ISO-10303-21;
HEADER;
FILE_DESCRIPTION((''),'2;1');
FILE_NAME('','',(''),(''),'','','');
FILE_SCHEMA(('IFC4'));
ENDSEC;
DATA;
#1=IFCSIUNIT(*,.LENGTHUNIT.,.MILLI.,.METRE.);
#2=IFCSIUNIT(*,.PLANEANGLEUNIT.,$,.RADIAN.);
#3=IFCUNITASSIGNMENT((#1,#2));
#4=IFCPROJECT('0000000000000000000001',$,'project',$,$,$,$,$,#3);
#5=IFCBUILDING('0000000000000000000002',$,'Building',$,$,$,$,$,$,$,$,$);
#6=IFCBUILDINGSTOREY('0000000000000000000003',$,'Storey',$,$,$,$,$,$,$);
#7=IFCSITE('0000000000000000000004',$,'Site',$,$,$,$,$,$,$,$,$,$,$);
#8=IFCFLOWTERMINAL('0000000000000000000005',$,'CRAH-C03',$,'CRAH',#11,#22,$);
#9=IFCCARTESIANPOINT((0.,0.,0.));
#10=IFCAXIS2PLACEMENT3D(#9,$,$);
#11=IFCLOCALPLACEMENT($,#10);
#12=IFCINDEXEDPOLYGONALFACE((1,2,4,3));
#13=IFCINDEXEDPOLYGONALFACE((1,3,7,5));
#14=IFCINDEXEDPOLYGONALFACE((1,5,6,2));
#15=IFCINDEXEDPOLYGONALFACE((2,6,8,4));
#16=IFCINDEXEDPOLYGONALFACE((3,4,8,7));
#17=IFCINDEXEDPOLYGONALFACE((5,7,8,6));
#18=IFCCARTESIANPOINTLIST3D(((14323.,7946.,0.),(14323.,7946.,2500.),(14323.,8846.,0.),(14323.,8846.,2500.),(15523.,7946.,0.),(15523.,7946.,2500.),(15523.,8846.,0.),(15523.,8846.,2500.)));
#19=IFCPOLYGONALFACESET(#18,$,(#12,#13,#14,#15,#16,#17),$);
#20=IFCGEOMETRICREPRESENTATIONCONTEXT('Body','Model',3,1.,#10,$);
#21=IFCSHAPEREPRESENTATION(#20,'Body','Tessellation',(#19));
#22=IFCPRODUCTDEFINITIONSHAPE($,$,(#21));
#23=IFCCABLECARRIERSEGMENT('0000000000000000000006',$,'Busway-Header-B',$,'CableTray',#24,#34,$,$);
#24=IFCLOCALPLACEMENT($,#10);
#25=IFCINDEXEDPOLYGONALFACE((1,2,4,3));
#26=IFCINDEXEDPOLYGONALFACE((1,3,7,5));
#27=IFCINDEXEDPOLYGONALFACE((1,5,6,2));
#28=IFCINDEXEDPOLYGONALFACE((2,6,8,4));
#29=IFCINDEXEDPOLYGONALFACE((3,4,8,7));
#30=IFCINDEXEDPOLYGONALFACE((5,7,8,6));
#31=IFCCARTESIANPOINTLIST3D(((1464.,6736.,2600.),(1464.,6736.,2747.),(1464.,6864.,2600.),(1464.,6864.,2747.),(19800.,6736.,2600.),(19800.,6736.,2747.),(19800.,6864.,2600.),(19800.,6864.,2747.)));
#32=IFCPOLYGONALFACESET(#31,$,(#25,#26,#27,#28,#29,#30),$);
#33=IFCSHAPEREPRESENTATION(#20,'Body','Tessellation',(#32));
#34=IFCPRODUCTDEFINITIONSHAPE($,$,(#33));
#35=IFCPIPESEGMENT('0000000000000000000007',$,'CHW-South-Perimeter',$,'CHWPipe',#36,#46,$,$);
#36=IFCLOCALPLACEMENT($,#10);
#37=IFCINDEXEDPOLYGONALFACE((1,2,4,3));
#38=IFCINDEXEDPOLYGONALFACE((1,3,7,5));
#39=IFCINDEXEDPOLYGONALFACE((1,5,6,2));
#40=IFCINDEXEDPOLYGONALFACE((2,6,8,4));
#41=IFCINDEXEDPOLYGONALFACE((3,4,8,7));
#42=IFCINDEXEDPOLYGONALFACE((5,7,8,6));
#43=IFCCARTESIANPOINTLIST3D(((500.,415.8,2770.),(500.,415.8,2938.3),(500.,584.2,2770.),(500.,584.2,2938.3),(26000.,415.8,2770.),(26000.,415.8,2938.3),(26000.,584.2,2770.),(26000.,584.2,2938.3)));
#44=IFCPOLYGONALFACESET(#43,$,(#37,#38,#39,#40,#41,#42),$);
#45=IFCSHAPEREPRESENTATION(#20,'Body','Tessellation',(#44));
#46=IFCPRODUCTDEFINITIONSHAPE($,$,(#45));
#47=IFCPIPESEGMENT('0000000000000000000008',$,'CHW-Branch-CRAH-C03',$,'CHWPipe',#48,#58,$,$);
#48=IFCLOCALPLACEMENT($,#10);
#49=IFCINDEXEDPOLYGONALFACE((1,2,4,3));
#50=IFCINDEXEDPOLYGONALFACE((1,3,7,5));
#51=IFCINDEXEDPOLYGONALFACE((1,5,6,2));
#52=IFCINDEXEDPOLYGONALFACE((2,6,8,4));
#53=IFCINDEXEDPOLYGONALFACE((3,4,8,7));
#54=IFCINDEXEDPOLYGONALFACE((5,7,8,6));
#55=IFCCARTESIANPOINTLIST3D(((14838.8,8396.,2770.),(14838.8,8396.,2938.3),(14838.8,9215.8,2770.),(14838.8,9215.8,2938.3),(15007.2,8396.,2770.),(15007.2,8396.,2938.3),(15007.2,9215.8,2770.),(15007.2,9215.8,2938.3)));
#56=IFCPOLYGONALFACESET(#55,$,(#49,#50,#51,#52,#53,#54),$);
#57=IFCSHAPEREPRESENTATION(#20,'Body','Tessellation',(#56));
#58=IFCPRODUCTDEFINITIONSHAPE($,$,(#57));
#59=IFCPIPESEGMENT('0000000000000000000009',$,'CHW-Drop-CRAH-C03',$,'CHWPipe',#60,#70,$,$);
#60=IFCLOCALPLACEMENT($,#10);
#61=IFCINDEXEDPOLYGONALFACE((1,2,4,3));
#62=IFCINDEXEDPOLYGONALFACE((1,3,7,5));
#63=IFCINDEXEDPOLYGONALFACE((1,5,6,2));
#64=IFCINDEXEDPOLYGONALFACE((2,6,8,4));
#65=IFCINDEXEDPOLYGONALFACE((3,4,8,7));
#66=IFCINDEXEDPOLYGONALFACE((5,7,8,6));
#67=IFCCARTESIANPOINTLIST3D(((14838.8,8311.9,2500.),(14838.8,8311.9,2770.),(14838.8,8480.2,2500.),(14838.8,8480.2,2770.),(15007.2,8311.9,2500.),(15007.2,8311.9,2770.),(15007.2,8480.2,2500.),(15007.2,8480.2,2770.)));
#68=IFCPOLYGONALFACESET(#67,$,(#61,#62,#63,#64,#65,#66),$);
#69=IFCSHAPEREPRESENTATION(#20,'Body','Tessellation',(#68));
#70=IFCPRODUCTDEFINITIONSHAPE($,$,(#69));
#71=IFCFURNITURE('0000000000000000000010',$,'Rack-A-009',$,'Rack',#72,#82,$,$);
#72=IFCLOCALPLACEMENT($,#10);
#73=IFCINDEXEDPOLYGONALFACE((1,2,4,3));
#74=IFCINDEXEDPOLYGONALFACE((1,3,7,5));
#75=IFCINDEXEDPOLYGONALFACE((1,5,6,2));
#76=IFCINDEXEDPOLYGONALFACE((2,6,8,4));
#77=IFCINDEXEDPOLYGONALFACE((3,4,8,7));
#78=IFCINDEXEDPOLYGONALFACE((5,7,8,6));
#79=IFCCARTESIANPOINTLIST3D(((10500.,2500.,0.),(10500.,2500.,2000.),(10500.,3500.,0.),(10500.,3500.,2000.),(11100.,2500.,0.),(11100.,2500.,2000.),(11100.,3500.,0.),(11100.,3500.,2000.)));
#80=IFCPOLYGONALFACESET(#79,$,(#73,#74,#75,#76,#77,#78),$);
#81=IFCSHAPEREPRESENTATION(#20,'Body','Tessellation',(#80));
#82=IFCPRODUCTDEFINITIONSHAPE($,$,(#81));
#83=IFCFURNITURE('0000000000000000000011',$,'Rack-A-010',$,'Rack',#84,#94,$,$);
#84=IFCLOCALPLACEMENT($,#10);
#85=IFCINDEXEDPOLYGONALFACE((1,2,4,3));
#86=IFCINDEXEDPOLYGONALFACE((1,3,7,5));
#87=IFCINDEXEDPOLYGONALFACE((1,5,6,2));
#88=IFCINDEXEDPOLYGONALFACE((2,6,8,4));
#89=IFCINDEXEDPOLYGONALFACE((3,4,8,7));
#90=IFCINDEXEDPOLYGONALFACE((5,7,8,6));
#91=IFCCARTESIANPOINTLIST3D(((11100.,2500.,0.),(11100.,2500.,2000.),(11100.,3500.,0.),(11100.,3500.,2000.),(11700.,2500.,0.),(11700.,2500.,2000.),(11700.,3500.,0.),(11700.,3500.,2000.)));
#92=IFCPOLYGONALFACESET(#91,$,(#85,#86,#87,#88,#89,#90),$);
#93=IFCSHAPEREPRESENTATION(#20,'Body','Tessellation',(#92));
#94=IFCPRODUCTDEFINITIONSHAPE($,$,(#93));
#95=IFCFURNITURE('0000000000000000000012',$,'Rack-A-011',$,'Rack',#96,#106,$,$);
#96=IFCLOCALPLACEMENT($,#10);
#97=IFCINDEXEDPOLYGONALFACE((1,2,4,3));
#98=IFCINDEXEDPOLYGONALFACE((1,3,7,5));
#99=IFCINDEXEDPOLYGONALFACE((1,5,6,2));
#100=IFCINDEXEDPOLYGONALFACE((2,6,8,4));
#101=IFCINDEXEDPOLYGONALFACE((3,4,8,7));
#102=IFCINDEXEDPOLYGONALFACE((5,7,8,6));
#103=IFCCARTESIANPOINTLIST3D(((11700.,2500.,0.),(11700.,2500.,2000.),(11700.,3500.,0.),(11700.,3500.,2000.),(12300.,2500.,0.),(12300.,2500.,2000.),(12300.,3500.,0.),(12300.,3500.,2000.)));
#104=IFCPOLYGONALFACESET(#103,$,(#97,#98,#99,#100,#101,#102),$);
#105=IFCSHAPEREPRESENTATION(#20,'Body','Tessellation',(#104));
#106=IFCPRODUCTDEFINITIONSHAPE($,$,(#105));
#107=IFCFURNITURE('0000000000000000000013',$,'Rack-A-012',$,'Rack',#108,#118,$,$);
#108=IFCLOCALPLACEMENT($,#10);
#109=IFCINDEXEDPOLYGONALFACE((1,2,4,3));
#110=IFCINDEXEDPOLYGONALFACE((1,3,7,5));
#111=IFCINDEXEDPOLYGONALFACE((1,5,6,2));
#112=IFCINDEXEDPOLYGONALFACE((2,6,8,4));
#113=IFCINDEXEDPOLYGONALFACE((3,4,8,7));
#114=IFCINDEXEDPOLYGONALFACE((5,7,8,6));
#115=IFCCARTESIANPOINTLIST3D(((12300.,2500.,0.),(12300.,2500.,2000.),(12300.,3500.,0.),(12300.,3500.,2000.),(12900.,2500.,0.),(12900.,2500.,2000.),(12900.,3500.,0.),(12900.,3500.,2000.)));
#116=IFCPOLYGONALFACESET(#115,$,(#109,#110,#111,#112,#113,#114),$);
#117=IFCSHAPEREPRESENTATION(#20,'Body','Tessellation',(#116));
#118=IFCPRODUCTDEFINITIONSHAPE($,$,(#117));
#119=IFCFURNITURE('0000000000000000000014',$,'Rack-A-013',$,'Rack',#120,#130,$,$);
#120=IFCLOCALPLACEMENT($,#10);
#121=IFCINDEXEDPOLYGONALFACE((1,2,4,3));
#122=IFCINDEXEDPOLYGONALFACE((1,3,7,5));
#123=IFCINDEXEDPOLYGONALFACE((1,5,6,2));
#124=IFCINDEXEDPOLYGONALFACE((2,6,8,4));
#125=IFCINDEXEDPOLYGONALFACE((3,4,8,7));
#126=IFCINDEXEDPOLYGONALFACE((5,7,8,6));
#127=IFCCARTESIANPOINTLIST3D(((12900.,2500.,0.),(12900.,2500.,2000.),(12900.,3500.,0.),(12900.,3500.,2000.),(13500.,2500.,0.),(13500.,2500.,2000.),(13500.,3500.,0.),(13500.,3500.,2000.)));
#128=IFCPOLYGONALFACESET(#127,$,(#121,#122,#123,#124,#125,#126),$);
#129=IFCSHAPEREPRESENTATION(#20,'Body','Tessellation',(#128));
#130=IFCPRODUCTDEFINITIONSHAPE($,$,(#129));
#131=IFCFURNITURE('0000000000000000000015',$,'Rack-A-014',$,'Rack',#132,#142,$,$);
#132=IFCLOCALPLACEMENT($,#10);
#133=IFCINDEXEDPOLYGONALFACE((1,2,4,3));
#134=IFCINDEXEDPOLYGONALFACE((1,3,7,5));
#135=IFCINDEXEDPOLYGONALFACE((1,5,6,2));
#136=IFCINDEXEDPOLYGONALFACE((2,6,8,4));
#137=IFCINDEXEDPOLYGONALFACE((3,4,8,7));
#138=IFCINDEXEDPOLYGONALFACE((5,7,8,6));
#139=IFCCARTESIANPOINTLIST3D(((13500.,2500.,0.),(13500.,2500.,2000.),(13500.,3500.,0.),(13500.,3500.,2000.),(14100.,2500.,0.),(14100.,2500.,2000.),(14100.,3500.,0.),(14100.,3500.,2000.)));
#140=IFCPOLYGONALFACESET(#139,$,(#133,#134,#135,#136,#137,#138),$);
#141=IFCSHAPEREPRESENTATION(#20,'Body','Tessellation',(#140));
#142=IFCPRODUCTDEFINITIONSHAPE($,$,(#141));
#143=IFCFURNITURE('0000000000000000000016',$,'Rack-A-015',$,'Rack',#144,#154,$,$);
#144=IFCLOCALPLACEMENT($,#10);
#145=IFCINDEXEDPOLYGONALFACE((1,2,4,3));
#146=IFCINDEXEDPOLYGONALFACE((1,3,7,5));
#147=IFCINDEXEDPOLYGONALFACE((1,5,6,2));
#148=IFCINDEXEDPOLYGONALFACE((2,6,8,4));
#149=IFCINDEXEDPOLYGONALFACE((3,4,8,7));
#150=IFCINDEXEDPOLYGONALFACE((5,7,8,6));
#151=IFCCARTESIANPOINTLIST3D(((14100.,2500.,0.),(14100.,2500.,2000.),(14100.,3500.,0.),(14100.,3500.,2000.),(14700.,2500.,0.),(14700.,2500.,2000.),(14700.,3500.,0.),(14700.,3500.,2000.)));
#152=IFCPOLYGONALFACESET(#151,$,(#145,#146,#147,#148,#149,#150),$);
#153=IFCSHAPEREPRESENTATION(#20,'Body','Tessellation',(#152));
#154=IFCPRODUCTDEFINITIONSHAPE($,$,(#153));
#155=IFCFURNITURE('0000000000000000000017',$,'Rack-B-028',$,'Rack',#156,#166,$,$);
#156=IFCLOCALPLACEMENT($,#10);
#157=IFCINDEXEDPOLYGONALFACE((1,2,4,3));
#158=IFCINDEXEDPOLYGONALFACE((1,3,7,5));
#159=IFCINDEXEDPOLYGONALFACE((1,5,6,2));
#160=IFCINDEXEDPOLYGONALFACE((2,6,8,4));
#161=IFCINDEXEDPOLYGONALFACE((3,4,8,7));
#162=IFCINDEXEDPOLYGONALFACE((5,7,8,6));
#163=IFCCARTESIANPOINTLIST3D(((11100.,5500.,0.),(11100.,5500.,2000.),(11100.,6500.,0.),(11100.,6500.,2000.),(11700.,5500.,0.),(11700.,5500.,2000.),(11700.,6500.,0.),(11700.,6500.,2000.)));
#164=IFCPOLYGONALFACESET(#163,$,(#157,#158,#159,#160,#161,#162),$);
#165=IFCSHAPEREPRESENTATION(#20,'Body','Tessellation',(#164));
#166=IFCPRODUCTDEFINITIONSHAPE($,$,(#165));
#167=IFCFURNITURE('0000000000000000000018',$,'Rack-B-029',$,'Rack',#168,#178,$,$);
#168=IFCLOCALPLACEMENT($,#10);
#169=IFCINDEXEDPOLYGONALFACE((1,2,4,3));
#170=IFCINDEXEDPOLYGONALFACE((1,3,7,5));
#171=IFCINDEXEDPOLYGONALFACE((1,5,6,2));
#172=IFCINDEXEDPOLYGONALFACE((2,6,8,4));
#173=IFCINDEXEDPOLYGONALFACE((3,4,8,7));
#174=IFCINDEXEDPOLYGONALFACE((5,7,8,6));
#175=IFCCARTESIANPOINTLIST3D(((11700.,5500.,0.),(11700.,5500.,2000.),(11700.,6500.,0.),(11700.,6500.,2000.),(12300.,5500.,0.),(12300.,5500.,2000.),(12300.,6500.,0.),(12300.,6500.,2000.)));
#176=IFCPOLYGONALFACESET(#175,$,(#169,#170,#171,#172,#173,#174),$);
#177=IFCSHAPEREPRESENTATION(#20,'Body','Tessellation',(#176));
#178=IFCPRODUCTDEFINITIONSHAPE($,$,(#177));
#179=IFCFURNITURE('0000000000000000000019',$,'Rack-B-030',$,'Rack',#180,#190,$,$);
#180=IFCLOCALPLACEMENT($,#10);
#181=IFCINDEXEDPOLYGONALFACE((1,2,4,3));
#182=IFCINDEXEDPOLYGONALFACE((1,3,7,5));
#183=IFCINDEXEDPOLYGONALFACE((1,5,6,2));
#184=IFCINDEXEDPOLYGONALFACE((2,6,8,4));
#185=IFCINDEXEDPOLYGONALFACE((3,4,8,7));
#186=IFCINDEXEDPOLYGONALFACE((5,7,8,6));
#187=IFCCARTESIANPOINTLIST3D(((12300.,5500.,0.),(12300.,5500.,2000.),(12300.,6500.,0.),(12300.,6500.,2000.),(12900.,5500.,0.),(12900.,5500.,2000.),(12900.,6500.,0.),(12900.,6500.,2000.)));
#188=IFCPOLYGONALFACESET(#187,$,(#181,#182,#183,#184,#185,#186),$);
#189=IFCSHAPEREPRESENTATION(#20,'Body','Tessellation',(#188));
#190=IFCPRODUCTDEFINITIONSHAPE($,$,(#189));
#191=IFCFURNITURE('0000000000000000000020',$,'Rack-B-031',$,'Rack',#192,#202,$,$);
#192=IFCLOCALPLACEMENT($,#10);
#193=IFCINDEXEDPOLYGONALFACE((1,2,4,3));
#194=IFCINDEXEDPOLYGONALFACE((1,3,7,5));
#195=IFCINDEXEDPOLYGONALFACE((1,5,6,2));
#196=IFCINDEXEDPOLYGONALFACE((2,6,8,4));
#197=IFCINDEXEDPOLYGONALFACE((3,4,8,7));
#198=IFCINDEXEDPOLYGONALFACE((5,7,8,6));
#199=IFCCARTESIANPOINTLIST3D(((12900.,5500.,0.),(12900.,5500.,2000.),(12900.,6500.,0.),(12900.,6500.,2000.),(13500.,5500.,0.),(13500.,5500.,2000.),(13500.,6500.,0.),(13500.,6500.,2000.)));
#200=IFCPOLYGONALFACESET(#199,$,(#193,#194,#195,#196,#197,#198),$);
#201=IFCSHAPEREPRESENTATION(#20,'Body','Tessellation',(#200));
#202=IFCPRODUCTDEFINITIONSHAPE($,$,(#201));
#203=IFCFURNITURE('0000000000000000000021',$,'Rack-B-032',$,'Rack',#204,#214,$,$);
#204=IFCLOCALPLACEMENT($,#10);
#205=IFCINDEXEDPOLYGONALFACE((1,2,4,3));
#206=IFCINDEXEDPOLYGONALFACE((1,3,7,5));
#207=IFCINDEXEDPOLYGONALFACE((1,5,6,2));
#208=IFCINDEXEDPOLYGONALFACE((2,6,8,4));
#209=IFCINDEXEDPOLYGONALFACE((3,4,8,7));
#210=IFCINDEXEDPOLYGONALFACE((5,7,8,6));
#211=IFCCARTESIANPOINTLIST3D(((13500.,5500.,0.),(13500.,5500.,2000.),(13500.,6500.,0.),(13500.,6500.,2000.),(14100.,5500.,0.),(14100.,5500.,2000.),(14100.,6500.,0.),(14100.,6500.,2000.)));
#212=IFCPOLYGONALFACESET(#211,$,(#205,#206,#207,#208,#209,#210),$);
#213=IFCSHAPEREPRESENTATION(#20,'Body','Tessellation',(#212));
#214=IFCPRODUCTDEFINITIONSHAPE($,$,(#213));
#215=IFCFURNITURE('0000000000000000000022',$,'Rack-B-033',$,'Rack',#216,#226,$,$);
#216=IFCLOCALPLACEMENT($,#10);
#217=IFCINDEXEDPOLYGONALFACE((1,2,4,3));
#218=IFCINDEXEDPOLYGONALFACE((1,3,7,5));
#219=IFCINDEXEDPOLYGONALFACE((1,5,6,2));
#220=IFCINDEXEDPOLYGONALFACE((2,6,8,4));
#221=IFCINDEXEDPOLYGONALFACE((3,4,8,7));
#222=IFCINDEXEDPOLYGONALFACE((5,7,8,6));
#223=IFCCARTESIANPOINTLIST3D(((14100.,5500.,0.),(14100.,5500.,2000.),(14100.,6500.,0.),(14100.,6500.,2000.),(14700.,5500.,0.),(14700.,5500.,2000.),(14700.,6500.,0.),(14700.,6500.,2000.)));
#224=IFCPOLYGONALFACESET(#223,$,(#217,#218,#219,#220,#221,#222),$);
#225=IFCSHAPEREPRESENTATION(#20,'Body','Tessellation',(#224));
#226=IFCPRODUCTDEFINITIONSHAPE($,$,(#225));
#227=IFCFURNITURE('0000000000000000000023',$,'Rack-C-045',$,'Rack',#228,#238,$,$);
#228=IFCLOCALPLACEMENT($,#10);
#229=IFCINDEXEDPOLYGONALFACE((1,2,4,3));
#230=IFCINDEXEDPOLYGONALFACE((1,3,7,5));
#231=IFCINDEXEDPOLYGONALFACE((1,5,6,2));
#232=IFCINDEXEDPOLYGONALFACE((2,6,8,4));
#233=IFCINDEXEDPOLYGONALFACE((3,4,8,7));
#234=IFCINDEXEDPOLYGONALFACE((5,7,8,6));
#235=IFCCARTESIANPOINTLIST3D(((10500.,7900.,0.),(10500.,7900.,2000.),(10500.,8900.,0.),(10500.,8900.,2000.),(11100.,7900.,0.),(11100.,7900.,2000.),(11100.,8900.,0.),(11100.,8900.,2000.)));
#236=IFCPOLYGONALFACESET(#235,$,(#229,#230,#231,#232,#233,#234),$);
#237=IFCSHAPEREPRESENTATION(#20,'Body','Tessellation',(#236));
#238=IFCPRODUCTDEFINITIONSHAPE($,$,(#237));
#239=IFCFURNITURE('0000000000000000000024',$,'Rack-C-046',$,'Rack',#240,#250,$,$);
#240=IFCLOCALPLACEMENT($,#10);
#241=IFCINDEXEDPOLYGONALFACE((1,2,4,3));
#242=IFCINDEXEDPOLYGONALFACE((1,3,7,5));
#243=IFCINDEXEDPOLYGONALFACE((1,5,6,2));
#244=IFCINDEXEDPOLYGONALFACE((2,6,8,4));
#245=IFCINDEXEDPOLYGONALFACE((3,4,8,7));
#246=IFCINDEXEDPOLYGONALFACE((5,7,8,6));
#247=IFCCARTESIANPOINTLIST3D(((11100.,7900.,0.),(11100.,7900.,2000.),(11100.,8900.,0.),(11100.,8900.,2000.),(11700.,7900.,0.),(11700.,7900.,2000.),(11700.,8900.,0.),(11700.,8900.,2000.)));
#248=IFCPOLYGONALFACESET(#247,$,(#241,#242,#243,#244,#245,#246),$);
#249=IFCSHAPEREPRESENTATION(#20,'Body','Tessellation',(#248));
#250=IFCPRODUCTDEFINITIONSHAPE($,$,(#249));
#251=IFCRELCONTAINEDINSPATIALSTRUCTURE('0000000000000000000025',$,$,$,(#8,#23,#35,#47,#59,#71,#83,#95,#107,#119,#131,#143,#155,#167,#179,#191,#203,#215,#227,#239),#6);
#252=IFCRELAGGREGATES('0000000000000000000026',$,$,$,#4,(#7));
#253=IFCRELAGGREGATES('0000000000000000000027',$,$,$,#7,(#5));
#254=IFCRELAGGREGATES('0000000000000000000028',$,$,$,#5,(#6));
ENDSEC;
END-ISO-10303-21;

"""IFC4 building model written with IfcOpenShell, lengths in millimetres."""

from ifc_helpers import new_model, si_unit, frame, origin, place, context, project, spatial, rectangle, extrude, element, save


model = new_model("IFC4")

# Units and contexts
model_context = context("Model", 3, precision=1.0, world=origin(), identifier="Body")
ifc_project = project(units=[si_unit("LENGTHUNIT", "METRE", prefix="MILLI"), si_unit("PLANEANGLEUNIT", "RADIAN")])

# Site, building, storey
site = spatial("IfcSite", under=ifc_project, Name="Site")
building = spatial("IfcBuilding", under=site, Name="Building")
storey = spatial("IfcBuildingStorey", under=building, Name="Storey")

# Flow terminal
flow_terminal_placement = place(None, frame((14923.0, 8396.0, 0.0), z_axis=(0.0, 0.0, 1.0), x_axis=(1.0, 0.0, 0.0)))
element("IfcFlowTerminal", 1, at=flow_terminal_placement, inside=storey, Name="CRAH-C03", ObjectType="CRAH", context=model_context, shape_type="SweptSolid", body=[
    extrude(rectangle(XDim=1200.0, YDim=900.0), origin(), (0.0, 0.0, 1.0), 2500.0),
])

# Cable carrier segment
cable_carrier_segment_placement = place(None, frame((10632.0, 6800.0, 2600.0), z_axis=(0.0, 0.0, 1.0), x_axis=(1.0, 0.0, 0.0)))
element("IfcCableCarrierSegment", 2, at=cable_carrier_segment_placement, inside=storey, Name="Busway-Header-B", ObjectType="CableTray", context=model_context, shape_type="SweptSolid", body=[
    extrude(rectangle(XDim=18336.0, YDim=128.0), origin(), (0.0, 0.0, 1.0), 147.0),
])

# Pipe segments
pipe_segment_1_placement = place(None, frame((13250.0, 500.0, 2770.0), z_axis=(0.0, 0.0, 1.0), x_axis=(1.0, 0.0, 0.0)))
element("IfcPipeSegment", 3, at=pipe_segment_1_placement, inside=storey, Name="CHW-South-Perimeter", ObjectType="CHWPipe", context=model_context, shape_type="SweptSolid", body=[
    extrude(rectangle(XDim=25500.0, YDim=168.3), origin(), (0.0, 0.0, 1.0), 168.3),
])
pipe_segment_2_placement = place(None, frame((14923.0, 8805.9, 2770.0), z_axis=(0.0, 0.0, 1.0), x_axis=(1.0, 0.0, 0.0)))
element("IfcPipeSegment", 4, at=pipe_segment_2_placement, inside=storey, Name="CHW-Branch-CRAH-C03", ObjectType="CHWPipe", context=model_context, shape_type="SweptSolid", body=[
    extrude(rectangle(XDim=168.3, YDim=819.9), origin(), (0.0, 0.0, 1.0), 168.3),
])
pipe_segment_3_placement = place(None, frame((14923.0, 8396.0, 2500.0), z_axis=(0.0, 0.0, 1.0), x_axis=(1.0, 0.0, 0.0)))
element("IfcPipeSegment", 5, at=pipe_segment_3_placement, inside=storey, Name="CHW-Drop-CRAH-C03", ObjectType="CHWPipe", context=model_context, shape_type="SweptSolid", body=[
    extrude(rectangle(XDim=168.3, YDim=168.3), origin(), (0.0, 0.0, 1.0), 270.0),
])

# Furniture
for number, where, z_axis, x_axis, name in (
    (6, (10800.0, 3000.0, 0.0), (0.0, 0.0, 1.0), (1.0, 0.0, 0.0), "Rack-A-009"),
    (7, (11400.0, 3000.0, 0.0), (0.0, 0.0, 1.0), (1.0, 0.0, 0.0), "Rack-A-010"),
    (8, (12000.0, 3000.0, 0.0), (0.0, 0.0, 1.0), (1.0, 0.0, 0.0), "Rack-A-011"),
    (9, (12600.0, 3000.0, 0.0), (0.0, 0.0, 1.0), (1.0, 0.0, 0.0), "Rack-A-012"),
    (10, (13200.0, 3000.0, 0.0), (0.0, 0.0, 1.0), (1.0, 0.0, 0.0), "Rack-A-013"),
    (11, (13800.0, 3000.0, 0.0), (0.0, 0.0, 1.0), (1.0, 0.0, 0.0), "Rack-A-014"),
    (12, (14400.0, 3000.0, 0.0), (0.0, 0.0, 1.0), (1.0, 0.0, 0.0), "Rack-A-015"),
    (13, (11400.0, 6000.0, 0.0), (0.0, 0.0, 1.0), (1.0, 0.0, 0.0), "Rack-B-028"),
    (14, (12000.0, 6000.0, 0.0), (0.0, 0.0, 1.0), (1.0, 0.0, 0.0), "Rack-B-029"),
    (15, (12600.0, 6000.0, 0.0), (0.0, 0.0, 1.0), (1.0, 0.0, 0.0), "Rack-B-030"),
    (16, (13200.0, 6000.0, 0.0), (0.0, 0.0, 1.0), (1.0, 0.0, 0.0), "Rack-B-031"),
    (17, (13800.0, 6000.0, 0.0), (0.0, 0.0, 1.0), (1.0, 0.0, 0.0), "Rack-B-032"),
    (18, (14400.0, 6000.0, 0.0), (0.0, 0.0, 1.0), (1.0, 0.0, 0.0), "Rack-B-033"),
    (19, (10800.0, 8400.0, 0.0), (0.0, 0.0, 1.0), (1.0, 0.0, 0.0), "Rack-C-045"),
    (20, (11400.0, 8400.0, 0.0), (0.0, 0.0, 1.0), (1.0, 0.0, 0.0), "Rack-C-046"),
):
    element("IfcFurniture", number, at=place(None, frame(where, z_axis=z_axis, x_axis=x_axis)), inside=storey, Name=name, ObjectType="Rack", context=model_context, shape_type="SweptSolid", body=[
        extrude(rectangle(XDim=600.0, YDim=1000.0), origin(), (0.0, 0.0, 1.0), 2000.0),
    ])

save(model, "model.ifc")
